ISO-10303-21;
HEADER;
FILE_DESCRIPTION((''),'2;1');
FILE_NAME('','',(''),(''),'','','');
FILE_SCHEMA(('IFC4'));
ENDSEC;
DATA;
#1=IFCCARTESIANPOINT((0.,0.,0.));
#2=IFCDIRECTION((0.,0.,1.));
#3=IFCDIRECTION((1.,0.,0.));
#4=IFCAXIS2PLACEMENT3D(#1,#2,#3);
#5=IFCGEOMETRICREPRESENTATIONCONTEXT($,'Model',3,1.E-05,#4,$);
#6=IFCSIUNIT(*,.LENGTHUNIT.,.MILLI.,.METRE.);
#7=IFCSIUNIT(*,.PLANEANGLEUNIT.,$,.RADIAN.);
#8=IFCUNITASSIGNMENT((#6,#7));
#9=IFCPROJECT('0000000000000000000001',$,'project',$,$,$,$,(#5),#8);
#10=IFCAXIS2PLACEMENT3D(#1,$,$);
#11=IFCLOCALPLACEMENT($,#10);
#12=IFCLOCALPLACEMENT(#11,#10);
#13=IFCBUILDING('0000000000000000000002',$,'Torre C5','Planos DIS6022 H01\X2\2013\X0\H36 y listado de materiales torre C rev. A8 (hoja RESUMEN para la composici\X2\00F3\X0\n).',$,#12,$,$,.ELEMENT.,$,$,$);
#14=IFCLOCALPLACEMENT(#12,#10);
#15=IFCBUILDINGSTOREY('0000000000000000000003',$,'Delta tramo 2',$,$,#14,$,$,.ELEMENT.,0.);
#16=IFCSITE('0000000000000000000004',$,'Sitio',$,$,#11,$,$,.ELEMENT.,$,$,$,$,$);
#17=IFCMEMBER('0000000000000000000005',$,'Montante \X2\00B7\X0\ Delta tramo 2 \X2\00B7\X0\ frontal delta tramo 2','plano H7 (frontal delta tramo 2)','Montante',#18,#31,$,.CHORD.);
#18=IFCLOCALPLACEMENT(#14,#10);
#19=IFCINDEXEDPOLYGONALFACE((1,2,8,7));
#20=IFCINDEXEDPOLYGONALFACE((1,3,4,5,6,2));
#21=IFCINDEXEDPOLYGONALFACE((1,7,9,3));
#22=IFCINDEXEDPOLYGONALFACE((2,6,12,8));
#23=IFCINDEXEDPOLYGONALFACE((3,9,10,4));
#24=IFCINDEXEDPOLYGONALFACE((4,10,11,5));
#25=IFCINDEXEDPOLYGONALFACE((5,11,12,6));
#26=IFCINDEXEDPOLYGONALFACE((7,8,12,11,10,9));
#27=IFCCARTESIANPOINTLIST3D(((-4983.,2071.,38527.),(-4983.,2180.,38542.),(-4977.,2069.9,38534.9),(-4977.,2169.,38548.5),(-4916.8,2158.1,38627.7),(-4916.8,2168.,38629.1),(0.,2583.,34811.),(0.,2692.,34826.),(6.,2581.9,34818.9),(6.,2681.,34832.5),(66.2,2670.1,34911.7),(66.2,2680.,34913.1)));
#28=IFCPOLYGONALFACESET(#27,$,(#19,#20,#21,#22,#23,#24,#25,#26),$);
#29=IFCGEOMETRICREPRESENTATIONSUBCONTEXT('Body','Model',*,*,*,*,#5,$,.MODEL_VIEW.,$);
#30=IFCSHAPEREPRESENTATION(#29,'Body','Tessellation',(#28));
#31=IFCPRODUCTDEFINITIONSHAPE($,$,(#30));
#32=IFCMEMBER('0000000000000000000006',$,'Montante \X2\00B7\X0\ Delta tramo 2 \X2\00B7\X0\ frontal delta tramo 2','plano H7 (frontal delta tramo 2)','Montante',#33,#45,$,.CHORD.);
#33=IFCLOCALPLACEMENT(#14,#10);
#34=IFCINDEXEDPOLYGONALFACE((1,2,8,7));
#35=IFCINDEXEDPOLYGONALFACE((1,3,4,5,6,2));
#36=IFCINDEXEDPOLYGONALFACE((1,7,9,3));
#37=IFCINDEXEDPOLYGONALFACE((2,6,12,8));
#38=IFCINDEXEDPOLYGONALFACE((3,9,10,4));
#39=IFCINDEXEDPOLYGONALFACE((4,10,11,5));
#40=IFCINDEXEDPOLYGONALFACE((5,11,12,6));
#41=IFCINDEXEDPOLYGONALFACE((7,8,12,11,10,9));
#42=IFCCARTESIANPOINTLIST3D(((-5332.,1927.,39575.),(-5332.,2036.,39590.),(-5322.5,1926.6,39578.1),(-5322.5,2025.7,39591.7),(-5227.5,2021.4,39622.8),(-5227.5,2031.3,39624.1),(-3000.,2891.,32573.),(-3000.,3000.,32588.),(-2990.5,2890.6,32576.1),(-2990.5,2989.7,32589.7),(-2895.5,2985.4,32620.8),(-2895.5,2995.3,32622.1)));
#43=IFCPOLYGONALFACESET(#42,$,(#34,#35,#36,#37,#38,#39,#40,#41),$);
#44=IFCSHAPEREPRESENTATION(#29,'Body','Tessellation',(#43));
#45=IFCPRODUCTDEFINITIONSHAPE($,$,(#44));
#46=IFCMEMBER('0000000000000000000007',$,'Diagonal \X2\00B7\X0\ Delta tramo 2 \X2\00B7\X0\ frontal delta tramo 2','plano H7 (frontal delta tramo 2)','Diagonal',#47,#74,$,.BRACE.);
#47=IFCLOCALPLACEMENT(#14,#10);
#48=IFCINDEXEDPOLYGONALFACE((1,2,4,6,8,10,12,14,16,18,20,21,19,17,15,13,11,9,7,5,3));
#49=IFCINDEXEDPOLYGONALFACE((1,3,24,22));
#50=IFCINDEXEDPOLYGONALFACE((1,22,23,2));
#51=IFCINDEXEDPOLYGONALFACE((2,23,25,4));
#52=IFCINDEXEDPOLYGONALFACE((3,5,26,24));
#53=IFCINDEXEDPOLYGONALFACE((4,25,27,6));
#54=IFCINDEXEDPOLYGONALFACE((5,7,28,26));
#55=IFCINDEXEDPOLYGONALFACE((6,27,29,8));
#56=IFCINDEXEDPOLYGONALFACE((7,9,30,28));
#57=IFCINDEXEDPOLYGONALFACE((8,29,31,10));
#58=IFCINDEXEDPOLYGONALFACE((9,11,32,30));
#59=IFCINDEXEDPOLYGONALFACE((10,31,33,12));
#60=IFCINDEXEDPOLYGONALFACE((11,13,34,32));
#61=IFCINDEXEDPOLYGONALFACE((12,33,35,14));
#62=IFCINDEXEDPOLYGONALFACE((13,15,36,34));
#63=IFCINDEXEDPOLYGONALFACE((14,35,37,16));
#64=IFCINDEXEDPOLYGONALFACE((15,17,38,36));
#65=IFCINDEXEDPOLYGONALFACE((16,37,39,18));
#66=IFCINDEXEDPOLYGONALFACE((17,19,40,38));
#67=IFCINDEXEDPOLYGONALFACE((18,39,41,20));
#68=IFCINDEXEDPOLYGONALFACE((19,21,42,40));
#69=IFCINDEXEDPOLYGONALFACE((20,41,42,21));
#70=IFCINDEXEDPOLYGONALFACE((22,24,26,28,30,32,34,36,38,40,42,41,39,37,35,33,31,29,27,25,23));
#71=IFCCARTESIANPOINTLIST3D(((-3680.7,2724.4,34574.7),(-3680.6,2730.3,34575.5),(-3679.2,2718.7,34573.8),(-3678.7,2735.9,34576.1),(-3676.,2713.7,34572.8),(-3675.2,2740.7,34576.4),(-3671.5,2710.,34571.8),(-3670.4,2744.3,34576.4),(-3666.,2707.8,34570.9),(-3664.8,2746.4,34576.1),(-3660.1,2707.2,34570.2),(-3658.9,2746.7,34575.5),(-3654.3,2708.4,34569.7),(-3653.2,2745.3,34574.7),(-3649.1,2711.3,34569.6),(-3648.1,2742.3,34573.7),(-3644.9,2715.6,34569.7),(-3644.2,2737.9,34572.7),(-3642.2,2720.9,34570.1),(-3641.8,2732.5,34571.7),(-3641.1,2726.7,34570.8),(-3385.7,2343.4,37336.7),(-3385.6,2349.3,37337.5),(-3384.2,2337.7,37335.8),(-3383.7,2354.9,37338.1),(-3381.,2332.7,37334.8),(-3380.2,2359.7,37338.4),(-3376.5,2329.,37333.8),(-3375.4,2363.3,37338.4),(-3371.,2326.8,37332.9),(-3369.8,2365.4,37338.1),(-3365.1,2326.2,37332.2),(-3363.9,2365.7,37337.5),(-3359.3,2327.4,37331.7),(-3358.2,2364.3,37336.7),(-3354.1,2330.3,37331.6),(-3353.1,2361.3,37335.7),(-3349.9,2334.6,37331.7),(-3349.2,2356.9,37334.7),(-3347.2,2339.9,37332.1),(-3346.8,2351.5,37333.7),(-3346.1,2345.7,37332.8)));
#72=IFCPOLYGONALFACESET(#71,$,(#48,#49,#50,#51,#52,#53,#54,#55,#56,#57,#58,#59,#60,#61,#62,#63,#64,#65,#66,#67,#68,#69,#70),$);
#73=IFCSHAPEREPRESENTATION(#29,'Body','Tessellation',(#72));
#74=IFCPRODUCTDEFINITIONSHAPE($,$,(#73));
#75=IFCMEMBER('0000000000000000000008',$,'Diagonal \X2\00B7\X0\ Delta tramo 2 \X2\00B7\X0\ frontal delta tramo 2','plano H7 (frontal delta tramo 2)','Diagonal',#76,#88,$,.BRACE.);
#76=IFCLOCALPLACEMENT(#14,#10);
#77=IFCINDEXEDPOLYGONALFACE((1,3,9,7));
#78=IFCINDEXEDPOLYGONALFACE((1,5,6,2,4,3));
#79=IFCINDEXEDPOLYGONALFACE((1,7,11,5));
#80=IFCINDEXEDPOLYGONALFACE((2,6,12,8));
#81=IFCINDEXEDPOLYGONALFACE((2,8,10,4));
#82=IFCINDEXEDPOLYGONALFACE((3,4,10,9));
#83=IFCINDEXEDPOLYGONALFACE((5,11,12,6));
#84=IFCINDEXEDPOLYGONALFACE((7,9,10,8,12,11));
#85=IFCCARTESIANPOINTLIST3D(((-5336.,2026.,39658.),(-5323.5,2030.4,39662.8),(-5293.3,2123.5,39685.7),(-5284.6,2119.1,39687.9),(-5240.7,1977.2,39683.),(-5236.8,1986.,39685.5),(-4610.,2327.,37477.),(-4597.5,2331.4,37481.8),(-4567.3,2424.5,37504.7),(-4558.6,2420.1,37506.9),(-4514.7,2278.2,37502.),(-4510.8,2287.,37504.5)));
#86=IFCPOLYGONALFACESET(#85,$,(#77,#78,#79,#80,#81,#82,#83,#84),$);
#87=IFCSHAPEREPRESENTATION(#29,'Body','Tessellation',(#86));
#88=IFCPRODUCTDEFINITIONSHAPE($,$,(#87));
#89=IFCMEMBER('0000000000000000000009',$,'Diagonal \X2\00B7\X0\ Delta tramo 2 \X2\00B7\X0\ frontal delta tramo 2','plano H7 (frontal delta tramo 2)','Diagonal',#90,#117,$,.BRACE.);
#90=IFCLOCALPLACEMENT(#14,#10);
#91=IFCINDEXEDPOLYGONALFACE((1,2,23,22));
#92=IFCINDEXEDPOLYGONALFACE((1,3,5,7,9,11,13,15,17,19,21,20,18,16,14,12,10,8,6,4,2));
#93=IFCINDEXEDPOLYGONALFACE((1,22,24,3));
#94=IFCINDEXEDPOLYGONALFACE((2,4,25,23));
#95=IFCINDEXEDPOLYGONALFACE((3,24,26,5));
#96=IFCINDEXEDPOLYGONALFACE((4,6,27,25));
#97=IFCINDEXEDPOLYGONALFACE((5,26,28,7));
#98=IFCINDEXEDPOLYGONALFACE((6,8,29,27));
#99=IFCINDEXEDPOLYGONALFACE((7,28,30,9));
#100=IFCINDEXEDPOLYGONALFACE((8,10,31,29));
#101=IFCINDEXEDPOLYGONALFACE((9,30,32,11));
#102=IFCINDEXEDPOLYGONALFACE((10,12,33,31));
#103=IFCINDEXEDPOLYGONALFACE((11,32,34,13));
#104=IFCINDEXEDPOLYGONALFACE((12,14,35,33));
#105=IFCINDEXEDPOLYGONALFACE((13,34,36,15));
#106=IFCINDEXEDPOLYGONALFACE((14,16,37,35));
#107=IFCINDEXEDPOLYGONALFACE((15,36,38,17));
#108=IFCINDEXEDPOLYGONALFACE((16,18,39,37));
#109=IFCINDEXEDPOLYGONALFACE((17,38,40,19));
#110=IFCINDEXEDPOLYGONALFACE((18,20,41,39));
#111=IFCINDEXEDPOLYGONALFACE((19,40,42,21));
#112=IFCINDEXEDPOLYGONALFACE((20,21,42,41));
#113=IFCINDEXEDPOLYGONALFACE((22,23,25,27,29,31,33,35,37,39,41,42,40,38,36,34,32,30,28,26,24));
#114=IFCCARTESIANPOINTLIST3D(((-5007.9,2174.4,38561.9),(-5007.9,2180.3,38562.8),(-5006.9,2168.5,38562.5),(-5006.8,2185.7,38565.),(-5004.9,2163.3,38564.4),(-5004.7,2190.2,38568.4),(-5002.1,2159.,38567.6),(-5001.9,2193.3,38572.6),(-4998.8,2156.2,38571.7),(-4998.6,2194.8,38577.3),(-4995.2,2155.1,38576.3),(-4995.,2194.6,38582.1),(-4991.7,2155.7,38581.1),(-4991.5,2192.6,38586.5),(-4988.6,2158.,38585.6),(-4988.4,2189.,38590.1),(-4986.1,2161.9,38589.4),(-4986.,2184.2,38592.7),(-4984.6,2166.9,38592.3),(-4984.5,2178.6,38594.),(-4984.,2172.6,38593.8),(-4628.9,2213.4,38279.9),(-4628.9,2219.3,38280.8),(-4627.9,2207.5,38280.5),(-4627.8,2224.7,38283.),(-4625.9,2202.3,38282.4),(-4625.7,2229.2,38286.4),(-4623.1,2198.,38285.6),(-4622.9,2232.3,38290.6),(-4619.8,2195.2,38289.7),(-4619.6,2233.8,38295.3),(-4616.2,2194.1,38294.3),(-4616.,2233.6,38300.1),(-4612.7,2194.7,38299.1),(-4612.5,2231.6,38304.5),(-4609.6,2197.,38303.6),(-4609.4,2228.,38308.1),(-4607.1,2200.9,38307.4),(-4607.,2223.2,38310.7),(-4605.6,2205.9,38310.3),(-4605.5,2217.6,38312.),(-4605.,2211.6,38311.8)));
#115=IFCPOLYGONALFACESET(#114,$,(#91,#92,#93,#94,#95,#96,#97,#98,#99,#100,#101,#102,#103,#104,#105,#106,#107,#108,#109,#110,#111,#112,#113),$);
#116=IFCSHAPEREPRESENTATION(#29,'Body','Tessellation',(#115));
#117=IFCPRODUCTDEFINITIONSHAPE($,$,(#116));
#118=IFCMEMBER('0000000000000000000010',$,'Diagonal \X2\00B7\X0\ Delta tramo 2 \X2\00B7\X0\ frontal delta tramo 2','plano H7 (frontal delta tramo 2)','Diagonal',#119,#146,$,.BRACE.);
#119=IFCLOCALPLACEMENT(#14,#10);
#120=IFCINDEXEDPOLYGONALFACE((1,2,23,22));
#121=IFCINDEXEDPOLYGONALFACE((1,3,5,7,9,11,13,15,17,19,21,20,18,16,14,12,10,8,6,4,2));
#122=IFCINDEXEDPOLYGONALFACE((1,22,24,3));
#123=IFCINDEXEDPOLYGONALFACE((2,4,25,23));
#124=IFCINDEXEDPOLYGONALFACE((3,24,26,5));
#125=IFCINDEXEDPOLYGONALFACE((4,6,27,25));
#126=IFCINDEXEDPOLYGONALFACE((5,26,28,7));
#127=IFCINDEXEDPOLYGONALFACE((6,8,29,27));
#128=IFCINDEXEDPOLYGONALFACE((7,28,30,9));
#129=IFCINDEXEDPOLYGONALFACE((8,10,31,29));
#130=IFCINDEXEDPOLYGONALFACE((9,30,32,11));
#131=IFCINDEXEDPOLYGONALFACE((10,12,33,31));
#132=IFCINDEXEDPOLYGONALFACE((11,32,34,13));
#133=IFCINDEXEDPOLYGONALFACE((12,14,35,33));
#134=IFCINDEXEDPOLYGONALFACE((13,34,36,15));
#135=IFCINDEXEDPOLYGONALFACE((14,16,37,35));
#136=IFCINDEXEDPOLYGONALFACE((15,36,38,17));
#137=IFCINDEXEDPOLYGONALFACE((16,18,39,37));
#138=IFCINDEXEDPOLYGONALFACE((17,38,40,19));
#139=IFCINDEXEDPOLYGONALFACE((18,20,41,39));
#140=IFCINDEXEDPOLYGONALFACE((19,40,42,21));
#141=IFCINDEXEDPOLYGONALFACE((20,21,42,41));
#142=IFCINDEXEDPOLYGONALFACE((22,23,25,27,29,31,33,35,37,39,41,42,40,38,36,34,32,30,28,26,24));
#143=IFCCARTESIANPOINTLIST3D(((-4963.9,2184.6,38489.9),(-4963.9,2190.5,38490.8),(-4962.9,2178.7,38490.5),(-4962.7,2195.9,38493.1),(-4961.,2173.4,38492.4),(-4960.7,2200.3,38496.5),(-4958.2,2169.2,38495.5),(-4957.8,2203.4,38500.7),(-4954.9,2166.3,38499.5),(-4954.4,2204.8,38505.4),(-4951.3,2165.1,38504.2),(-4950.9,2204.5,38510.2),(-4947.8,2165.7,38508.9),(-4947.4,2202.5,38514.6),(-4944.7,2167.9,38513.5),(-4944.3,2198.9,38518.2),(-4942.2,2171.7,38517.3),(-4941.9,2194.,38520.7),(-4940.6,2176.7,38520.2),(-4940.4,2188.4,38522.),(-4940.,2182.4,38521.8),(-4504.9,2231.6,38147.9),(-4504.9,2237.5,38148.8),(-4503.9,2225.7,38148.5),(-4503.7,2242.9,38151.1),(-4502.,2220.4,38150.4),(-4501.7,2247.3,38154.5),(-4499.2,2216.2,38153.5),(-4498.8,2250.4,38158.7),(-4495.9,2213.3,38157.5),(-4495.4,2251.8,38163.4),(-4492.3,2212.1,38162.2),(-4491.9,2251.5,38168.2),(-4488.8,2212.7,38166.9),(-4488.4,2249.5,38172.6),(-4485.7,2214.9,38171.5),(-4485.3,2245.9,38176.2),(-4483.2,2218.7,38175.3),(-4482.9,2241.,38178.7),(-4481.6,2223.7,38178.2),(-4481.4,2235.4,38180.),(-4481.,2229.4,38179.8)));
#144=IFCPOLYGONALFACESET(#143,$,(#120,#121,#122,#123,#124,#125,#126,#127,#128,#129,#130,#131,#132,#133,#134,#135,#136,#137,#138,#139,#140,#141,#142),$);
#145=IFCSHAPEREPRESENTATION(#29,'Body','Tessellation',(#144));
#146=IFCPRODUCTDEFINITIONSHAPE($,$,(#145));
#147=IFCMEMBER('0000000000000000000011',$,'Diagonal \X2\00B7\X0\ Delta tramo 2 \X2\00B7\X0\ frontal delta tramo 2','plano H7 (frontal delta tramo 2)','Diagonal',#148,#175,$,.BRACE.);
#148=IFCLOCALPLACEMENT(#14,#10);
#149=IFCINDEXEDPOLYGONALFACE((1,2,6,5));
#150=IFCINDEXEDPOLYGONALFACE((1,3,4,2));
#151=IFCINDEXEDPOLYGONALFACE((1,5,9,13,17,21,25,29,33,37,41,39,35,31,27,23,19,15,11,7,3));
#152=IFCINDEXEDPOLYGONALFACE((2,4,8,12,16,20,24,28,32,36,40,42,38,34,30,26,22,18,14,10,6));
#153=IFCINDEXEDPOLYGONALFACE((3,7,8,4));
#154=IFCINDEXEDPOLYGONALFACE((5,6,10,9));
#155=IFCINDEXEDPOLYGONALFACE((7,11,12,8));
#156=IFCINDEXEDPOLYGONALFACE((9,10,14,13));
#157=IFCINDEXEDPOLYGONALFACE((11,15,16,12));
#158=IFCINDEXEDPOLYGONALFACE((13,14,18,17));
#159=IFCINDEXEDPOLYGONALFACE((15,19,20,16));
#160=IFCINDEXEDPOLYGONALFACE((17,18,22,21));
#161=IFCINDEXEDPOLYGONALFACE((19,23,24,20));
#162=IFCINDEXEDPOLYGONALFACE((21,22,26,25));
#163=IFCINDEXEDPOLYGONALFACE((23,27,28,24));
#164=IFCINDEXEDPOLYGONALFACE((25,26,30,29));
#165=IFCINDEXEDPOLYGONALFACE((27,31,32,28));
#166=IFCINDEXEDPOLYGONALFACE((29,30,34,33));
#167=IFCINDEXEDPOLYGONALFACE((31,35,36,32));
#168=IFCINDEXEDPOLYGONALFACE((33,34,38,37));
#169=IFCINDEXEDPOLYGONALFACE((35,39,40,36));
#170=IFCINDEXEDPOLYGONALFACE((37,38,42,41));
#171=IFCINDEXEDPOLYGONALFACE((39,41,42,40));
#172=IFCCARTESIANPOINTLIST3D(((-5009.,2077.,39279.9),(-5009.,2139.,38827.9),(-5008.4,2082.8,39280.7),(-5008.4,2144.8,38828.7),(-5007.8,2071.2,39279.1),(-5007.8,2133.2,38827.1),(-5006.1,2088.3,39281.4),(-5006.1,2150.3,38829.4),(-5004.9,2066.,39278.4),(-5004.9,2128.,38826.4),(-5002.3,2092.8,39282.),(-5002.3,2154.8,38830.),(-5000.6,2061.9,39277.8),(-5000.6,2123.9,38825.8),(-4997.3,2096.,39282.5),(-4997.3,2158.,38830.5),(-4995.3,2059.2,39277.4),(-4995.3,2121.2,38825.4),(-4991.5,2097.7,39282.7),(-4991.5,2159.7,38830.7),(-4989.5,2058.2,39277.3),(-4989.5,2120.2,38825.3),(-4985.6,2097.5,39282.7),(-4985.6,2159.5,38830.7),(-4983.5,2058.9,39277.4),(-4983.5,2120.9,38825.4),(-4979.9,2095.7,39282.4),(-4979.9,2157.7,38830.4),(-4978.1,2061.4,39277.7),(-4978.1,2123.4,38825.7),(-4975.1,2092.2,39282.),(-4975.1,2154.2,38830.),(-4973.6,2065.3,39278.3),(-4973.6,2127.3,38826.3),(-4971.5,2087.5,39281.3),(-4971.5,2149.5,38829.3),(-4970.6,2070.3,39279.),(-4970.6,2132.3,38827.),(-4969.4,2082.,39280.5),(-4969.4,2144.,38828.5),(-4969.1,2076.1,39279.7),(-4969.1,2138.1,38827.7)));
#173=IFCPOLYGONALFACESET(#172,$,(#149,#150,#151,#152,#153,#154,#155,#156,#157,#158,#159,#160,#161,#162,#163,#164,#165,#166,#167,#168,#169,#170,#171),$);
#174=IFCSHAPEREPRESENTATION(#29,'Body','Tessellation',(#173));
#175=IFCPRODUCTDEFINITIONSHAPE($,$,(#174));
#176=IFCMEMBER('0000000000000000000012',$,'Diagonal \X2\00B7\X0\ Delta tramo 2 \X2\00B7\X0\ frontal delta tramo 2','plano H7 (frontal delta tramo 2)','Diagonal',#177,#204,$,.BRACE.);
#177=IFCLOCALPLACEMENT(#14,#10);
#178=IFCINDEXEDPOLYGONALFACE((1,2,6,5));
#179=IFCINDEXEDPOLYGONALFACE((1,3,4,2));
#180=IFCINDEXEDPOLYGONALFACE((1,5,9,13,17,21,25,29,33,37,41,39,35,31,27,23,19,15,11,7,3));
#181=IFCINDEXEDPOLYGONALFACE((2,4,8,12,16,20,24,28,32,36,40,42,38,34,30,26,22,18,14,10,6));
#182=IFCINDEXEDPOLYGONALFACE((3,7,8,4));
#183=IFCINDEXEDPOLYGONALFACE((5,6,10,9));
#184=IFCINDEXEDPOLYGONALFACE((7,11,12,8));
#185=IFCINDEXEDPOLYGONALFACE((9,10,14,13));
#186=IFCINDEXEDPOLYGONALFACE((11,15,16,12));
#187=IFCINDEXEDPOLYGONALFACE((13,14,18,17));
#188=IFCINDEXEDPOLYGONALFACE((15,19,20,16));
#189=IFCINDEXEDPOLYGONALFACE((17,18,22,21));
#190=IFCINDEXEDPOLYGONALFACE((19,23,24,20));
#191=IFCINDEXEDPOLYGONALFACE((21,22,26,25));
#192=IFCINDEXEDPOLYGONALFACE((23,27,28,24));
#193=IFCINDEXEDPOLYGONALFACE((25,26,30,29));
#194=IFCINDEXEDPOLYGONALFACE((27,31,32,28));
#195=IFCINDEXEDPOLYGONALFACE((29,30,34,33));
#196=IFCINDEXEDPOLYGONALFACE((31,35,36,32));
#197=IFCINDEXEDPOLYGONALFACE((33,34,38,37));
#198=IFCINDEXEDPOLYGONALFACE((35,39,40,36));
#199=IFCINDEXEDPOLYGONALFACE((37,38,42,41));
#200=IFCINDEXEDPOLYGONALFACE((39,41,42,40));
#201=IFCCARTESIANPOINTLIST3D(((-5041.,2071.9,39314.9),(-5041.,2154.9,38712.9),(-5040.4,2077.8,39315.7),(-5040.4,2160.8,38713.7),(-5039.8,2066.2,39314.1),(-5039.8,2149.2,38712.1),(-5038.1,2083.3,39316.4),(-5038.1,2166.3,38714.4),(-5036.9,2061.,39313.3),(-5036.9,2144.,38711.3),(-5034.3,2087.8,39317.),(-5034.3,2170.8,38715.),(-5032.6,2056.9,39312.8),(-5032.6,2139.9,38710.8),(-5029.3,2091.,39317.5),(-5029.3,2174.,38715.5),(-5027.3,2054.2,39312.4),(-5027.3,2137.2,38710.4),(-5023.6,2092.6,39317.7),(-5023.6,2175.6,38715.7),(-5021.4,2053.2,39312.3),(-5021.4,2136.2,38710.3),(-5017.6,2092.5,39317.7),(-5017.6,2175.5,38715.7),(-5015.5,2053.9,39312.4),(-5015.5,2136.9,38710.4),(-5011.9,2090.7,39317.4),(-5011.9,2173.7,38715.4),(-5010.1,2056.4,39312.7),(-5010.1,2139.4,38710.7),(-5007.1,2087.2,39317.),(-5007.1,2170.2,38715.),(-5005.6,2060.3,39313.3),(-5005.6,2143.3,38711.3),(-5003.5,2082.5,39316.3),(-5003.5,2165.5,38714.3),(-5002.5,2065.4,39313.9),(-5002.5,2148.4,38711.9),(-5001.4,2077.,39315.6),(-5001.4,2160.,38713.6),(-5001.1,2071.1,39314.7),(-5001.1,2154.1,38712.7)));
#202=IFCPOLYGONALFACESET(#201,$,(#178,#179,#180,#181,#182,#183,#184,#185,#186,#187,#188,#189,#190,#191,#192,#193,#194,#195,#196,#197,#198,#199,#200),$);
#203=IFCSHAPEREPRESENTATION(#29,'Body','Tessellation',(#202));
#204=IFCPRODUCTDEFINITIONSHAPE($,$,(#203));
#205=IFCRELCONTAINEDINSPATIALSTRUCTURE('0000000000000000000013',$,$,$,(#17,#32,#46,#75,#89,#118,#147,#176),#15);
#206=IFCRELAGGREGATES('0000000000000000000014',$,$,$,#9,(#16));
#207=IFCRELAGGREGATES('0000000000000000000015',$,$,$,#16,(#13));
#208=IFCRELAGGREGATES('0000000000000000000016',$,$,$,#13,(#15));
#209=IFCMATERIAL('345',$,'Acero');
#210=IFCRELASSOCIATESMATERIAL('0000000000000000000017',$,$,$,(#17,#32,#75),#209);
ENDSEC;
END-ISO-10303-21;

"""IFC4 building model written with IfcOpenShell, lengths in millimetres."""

from ifc_helpers import new_model, si_unit, frame, frame_2d, origin, origin_with_axes, place, context, subcontext, project, spatial, circle, l_section, extrude, material, element, save


model = new_model("IFC4")

# Units and contexts
model_context = context("Model", 3, precision=1e-05, world=origin_with_axes())
body_context = subcontext(model_context, "Body", "Model", "MODEL_VIEW")
ifc_project = project(units=[si_unit("LENGTHUNIT", "METRE", prefix="MILLI"), si_unit("PLANEANGLEUNIT", "RADIAN")], contexts=[model_context])

# Site, building, storey
site_placement = place(None, origin())
site = spatial("IfcSite", under=ifc_project, at=site_placement, Name="Sitio", CompositionType="ELEMENT")
building_placement = place(site_placement, origin())
building = spatial("IfcBuilding", under=site, at=building_placement, Name="Torre C5", Description="Planos DIS6022 H01–H36 y listado de materiales torre C rev. A8 (hoja RESUMEN para la composición).", CompositionType="ELEMENT")
storey_placement = place(building_placement, origin())
storey = spatial("IfcBuildingStorey", under=building, at=storey_placement, Name="Delta tramo 2", CompositionType="ELEMENT", Elevation=0.0)

# Members
ifc_material_1 = material(Name="345", Category="Acero")
member_1_placement = place(storey_placement, frame((-4983.0, 2180.0, 38542.0), z_axis=(0.798932, 0.08209, -0.595792), x_axis=(0.601421, -0.109049, 0.791455)))
element("IfcMember", 1, at=member_1_placement, inside=storey, material=ifc_material_1, Name="Montante · Delta tramo 2 · frontal delta tramo 2", Description="plano H7 (frontal delta tramo 2)", ObjectType="Montante", PredefinedType="CHORD", context=body_context, shape_type="SweptSolid", body=[
    extrude(l_section(Depth=110.0, Width=110.0, Thickness=10.0, at=frame_2d((55.0, 55.0))), None, (0.0, 0.0, 1.0), 6237.1),
])
member_2_placement = place(storey_placement, frame((-5332.0, 2036.0, 39590.0), z_axis=(0.313322, 0.129521, -0.940773), x_axis=(0.949647, -0.042734, 0.310394)))
element("IfcMember", 2, at=member_2_placement, inside=storey, material=ifc_material_1, Name="Montante · Delta tramo 2 · frontal delta tramo 2", Description="plano H7 (frontal delta tramo 2)", ObjectType="Montante", PredefinedType="CHORD", context=body_context, shape_type="SweptSolid", body=[
    extrude(l_section(Depth=110.0, Width=110.0, Thickness=10.0, at=frame_2d((55.0, 55.0))), None, (0.0, 0.0, 1.0), 7442.8),
])
member_3_placement = place(storey_placement, frame((-3366.0, 2346.0, 37335.0), z_axis=(-0.105217, 0.135891, -0.985121), x_axis=(0.804453, -0.570742, -0.164651)))
element("IfcMember", 3, at=member_3_placement, inside=storey, Name="Diagonal · Delta tramo 2 · frontal delta tramo 2", Description="plano H7 (frontal delta tramo 2)", ObjectType="Diagonal", PredefinedType="BRACE", context=body_context, shape_type="SweptSolid", body=[
    extrude(circle(Radius=20.0), None, (0.0, 0.0, 1.0), 2803.7),
])
member_4_placement = place(storey_placement, frame((-4610.0, 2327.0, 37477.0), z_axis=(-0.313163, -0.129837, 0.940782), x_axis=(0.866801, -0.443846, 0.227281)))
element("IfcMember", 4, at=member_4_placement, inside=storey, material=ifc_material_1, Name="Diagonal · Delta tramo 2 · frontal delta tramo 2", Description="plano H7 (frontal delta tramo 2)", ObjectType="Diagonal", PredefinedType="BRACE", context=body_context, shape_type="SweptSolid", body=[
    extrude(l_section(Depth=110.0, Width=110.0, Thickness=10.0, at=frame_2d((55.0, 55.0))), None, (0.0, 0.0, 1.0), 2318.3),
])
member_5_placement = place(storey_placement, frame((-4996.0, 2175.0, 38578.0), z_axis=(0.79956, 0.082277, -0.594923), x_axis=(0.493139, -0.655346, 0.572132)))
element("IfcMember", 5, at=member_5_placement, inside=storey, Name="Diagonal · Delta tramo 2 · frontal delta tramo 2", Description="plano H7 (frontal delta tramo 2)", ObjectType="Diagonal", PredefinedType="BRACE", context=body_context, shape_type="SweptSolid", body=[
    extrude(circle(Radius=20.0), None, (0.0, 0.0, 1.0), 474.0),
])
member_6_placement = place(storey_placement, frame((-4952.0, 2185.0, 38506.0), z_axis=(0.799193, 0.081835, -0.595477), x_axis=(0.48996, -0.662562, 0.566524)))
element("IfcMember", 6, at=member_6_placement, inside=storey, Name="Diagonal · Delta tramo 2 · frontal delta tramo 2", Description="plano H7 (frontal delta tramo 2)", ObjectType="Diagonal", PredefinedType="BRACE", context=body_context, shape_type="SweptSolid", body=[
    extrude(circle(Radius=20.0), None, (0.0, 0.0, 1.0), 574.3),
])
member_7_placement = place(storey_placement, frame((-4989.0, 2140.0, 38828.0), z_axis=(0.0, -0.135896, 0.990723), x_axis=(0.922374, -0.382714, -0.052496)))
element("IfcMember", 7, at=member_7_placement, inside=storey, Name="Diagonal · Delta tramo 2 · frontal delta tramo 2", Description="plano H7 (frontal delta tramo 2)", ObjectType="Diagonal", PredefinedType="BRACE", context=body_context, shape_type="SweptSolid", body=[
    extrude(circle(Radius=20.0), None, (0.0, 0.0, 1.0), 456.2),
])
member_8_placement = place(storey_placement, frame((-5021.0, 2156.0, 38713.0), z_axis=(0.0, -0.136582, 0.990629), x_axis=(0.922907, -0.381415, -0.052587)))
element("IfcMember", 8, at=member_8_placement, inside=storey, Name="Diagonal · Delta tramo 2 · frontal delta tramo 2", Description="plano H7 (frontal delta tramo 2)", ObjectType="Diagonal", PredefinedType="BRACE", context=body_context, shape_type="SweptSolid", body=[
    extrude(circle(Radius=20.0), None, (0.0, 0.0, 1.0), 607.7),
])

save(model, "model.ifc")
